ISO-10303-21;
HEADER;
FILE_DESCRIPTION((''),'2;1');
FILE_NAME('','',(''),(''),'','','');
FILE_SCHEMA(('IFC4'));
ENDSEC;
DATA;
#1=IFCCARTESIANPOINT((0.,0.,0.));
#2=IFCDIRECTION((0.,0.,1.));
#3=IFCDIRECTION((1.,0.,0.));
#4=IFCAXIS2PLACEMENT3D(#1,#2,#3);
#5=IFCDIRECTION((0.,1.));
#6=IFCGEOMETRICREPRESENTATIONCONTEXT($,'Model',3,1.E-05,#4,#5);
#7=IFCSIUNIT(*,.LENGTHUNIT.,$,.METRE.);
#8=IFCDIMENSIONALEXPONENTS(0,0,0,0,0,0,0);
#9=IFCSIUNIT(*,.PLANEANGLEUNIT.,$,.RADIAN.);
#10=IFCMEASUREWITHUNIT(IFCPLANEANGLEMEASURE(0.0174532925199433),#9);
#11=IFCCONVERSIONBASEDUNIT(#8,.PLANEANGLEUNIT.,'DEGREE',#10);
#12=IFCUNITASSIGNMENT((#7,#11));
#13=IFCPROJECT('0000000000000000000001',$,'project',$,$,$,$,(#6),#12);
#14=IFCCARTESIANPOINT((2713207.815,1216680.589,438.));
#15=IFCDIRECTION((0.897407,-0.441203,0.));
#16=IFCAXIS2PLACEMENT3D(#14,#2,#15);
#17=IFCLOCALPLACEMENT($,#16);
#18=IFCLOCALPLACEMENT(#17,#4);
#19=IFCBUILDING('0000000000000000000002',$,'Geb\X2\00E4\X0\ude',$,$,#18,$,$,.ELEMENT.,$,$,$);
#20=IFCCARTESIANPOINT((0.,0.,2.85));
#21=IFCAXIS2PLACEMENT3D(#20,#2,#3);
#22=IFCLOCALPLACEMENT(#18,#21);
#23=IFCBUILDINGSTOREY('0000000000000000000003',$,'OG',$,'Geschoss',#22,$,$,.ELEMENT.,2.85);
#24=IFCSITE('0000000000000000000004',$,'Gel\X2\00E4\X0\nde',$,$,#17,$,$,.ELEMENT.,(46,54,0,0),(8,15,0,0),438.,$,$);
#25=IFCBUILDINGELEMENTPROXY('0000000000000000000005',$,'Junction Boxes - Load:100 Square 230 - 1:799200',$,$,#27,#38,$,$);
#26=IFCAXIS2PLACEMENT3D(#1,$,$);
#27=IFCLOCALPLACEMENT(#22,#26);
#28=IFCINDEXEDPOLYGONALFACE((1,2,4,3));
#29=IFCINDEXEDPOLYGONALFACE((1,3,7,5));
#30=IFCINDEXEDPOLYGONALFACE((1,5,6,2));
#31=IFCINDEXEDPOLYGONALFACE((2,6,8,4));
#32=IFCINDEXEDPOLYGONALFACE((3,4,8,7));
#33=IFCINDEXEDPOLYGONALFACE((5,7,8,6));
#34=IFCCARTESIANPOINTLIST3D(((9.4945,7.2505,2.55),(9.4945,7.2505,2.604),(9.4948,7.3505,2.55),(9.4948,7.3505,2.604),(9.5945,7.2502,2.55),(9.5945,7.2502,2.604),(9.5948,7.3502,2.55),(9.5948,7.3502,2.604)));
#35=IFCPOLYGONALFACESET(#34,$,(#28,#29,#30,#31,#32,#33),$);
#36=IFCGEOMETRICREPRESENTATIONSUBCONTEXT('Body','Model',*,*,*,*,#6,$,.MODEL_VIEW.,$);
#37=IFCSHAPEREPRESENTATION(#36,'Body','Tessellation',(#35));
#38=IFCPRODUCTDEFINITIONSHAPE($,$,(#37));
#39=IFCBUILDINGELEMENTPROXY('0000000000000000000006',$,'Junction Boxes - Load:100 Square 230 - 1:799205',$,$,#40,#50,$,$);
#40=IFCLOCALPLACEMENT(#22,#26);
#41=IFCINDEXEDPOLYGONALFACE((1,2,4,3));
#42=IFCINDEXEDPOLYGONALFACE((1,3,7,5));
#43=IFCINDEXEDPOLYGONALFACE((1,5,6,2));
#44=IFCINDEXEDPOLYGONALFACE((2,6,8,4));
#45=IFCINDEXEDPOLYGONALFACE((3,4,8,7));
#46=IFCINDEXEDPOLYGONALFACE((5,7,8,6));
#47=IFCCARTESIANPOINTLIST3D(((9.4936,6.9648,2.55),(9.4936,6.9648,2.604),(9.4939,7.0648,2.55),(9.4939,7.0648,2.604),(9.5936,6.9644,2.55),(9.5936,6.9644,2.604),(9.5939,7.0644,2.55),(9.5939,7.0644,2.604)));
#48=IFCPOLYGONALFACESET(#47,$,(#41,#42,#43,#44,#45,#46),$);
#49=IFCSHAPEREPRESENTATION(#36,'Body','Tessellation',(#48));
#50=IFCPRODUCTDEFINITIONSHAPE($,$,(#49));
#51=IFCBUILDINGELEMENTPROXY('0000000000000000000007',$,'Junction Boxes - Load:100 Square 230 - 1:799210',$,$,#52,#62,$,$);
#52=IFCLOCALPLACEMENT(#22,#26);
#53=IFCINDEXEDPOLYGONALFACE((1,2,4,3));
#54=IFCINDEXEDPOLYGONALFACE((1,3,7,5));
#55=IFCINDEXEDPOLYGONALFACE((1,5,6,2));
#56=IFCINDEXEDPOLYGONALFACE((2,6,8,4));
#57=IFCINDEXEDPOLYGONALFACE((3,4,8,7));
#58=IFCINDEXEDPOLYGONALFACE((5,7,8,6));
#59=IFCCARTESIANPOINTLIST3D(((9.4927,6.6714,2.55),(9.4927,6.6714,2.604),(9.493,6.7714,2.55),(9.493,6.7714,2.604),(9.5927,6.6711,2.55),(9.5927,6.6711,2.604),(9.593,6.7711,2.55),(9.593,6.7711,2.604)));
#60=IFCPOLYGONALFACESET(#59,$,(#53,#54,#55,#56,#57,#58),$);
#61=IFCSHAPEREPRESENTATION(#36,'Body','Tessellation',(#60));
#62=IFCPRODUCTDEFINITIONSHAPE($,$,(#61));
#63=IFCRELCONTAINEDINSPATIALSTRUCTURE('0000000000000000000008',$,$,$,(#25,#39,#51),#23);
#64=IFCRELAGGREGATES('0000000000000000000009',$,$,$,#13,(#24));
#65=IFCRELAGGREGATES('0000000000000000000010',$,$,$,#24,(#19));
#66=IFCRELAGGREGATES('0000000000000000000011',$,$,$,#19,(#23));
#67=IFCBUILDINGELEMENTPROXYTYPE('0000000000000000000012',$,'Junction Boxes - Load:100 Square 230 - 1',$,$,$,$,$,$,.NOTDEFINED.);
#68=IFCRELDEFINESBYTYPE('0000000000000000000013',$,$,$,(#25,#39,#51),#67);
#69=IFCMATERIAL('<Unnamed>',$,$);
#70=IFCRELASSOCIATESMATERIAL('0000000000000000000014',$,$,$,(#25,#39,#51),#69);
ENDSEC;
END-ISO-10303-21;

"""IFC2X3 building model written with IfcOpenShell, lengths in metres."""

from ifc_helpers import new_model, entity, si_unit, converted_unit, direction, frame, origin_with_axes, origin_2d_with_axis, place, context, subcontext, project, spatial, rectangle, extrude, material, type_object, element, save


model = new_model("IFC2X3")

# Units and contexts
model_context = context("Model", 3, precision=1e-05, world=origin_with_axes(), true_north=direction((0.0, 1.0)))
body_context = subcontext(model_context, "Body", "Model", "MODEL_VIEW")
ifc_project = project(units=[si_unit("LENGTHUNIT", "METRE"), converted_unit("PLANEANGLEUNIT", "DEGREE", entity("IfcPlaneAngleMeasure", 0.0174532925199433), si_unit("PLANEANGLEUNIT", "RADIAN"), dimensions=[0, 0, 0, 0, 0, 0, 0])], contexts=[model_context])

# Site, building, storey
site_placement = place(None, frame((2713207.815, 1216680.589, 438.0), z_axis=(0.0, 0.0, 1.0), x_axis=(0.897407, -0.441203, 0.0)))
site = spatial("IfcSite", under=ifc_project, at=site_placement, Name="Gelände", CompositionType="ELEMENT", RefLatitude=(46, 54, 0, 0), RefLongitude=(8, 15, 0, 0), RefElevation=438.0)
building_placement = place(site_placement, origin_with_axes())
building = spatial("IfcBuilding", under=site, at=building_placement, Name="Gebäude", CompositionType="ELEMENT")
storey_placement = place(building_placement, frame((0.0, 0.0, 2.85), z_axis=(0.0, 0.0, 1.0), x_axis=(1.0, 0.0, 0.0)))
storey = spatial("IfcBuildingStorey", under=building, at=storey_placement, Name="OG", ObjectType="Geschoss", CompositionType="ELEMENT", Elevation=2.85)

# Building element proxies
ifc_material = material(Name="<Unnamed>")
building_element_proxy_type = type_object("IfcBuildingElementProxyType", Name="Junction Boxes - Load:100 Square 230 - 1", PredefinedType="NOTDEFINED")
for number, where, z_axis, x_axis, name in (
    (1, (9.5446, 7.3003, 2.55), (0.0, 0.0, 1.0), (-0.00313, -0.999995, 0.0), "Junction Boxes - Load:100 Square 230 - 1:799200"),
    (2, (9.5437, 7.0146, 2.55), (0.0, 0.0, 1.0), (-0.00313, -0.999995, 0.0), "Junction Boxes - Load:100 Square 230 - 1:799205"),
    (3, (9.5428, 6.7213, 2.55), (0.0, 0.0, 1.0), (-0.00313, -0.999995, 0.0), "Junction Boxes - Load:100 Square 230 - 1:799210"),
):
    element("IfcBuildingElementProxy", number, at=place(storey_placement, frame(where, z_axis=z_axis, x_axis=x_axis)), inside=storey, type_object=building_element_proxy_type, material=ifc_material, Name=name, context=body_context, shape_type="SweptSolid", body=[
        extrude(rectangle(XDim=0.1, YDim=0.1, at=origin_2d_with_axis()), frame((0.0, 0.0, 0.0), z_axis=(0.0, 0.0, 1.0), x_axis=(-1.0, 0.0, 0.0)), (0.0, 0.0, 1.0), 0.054),
    ])

save(model, "model.ifc")
